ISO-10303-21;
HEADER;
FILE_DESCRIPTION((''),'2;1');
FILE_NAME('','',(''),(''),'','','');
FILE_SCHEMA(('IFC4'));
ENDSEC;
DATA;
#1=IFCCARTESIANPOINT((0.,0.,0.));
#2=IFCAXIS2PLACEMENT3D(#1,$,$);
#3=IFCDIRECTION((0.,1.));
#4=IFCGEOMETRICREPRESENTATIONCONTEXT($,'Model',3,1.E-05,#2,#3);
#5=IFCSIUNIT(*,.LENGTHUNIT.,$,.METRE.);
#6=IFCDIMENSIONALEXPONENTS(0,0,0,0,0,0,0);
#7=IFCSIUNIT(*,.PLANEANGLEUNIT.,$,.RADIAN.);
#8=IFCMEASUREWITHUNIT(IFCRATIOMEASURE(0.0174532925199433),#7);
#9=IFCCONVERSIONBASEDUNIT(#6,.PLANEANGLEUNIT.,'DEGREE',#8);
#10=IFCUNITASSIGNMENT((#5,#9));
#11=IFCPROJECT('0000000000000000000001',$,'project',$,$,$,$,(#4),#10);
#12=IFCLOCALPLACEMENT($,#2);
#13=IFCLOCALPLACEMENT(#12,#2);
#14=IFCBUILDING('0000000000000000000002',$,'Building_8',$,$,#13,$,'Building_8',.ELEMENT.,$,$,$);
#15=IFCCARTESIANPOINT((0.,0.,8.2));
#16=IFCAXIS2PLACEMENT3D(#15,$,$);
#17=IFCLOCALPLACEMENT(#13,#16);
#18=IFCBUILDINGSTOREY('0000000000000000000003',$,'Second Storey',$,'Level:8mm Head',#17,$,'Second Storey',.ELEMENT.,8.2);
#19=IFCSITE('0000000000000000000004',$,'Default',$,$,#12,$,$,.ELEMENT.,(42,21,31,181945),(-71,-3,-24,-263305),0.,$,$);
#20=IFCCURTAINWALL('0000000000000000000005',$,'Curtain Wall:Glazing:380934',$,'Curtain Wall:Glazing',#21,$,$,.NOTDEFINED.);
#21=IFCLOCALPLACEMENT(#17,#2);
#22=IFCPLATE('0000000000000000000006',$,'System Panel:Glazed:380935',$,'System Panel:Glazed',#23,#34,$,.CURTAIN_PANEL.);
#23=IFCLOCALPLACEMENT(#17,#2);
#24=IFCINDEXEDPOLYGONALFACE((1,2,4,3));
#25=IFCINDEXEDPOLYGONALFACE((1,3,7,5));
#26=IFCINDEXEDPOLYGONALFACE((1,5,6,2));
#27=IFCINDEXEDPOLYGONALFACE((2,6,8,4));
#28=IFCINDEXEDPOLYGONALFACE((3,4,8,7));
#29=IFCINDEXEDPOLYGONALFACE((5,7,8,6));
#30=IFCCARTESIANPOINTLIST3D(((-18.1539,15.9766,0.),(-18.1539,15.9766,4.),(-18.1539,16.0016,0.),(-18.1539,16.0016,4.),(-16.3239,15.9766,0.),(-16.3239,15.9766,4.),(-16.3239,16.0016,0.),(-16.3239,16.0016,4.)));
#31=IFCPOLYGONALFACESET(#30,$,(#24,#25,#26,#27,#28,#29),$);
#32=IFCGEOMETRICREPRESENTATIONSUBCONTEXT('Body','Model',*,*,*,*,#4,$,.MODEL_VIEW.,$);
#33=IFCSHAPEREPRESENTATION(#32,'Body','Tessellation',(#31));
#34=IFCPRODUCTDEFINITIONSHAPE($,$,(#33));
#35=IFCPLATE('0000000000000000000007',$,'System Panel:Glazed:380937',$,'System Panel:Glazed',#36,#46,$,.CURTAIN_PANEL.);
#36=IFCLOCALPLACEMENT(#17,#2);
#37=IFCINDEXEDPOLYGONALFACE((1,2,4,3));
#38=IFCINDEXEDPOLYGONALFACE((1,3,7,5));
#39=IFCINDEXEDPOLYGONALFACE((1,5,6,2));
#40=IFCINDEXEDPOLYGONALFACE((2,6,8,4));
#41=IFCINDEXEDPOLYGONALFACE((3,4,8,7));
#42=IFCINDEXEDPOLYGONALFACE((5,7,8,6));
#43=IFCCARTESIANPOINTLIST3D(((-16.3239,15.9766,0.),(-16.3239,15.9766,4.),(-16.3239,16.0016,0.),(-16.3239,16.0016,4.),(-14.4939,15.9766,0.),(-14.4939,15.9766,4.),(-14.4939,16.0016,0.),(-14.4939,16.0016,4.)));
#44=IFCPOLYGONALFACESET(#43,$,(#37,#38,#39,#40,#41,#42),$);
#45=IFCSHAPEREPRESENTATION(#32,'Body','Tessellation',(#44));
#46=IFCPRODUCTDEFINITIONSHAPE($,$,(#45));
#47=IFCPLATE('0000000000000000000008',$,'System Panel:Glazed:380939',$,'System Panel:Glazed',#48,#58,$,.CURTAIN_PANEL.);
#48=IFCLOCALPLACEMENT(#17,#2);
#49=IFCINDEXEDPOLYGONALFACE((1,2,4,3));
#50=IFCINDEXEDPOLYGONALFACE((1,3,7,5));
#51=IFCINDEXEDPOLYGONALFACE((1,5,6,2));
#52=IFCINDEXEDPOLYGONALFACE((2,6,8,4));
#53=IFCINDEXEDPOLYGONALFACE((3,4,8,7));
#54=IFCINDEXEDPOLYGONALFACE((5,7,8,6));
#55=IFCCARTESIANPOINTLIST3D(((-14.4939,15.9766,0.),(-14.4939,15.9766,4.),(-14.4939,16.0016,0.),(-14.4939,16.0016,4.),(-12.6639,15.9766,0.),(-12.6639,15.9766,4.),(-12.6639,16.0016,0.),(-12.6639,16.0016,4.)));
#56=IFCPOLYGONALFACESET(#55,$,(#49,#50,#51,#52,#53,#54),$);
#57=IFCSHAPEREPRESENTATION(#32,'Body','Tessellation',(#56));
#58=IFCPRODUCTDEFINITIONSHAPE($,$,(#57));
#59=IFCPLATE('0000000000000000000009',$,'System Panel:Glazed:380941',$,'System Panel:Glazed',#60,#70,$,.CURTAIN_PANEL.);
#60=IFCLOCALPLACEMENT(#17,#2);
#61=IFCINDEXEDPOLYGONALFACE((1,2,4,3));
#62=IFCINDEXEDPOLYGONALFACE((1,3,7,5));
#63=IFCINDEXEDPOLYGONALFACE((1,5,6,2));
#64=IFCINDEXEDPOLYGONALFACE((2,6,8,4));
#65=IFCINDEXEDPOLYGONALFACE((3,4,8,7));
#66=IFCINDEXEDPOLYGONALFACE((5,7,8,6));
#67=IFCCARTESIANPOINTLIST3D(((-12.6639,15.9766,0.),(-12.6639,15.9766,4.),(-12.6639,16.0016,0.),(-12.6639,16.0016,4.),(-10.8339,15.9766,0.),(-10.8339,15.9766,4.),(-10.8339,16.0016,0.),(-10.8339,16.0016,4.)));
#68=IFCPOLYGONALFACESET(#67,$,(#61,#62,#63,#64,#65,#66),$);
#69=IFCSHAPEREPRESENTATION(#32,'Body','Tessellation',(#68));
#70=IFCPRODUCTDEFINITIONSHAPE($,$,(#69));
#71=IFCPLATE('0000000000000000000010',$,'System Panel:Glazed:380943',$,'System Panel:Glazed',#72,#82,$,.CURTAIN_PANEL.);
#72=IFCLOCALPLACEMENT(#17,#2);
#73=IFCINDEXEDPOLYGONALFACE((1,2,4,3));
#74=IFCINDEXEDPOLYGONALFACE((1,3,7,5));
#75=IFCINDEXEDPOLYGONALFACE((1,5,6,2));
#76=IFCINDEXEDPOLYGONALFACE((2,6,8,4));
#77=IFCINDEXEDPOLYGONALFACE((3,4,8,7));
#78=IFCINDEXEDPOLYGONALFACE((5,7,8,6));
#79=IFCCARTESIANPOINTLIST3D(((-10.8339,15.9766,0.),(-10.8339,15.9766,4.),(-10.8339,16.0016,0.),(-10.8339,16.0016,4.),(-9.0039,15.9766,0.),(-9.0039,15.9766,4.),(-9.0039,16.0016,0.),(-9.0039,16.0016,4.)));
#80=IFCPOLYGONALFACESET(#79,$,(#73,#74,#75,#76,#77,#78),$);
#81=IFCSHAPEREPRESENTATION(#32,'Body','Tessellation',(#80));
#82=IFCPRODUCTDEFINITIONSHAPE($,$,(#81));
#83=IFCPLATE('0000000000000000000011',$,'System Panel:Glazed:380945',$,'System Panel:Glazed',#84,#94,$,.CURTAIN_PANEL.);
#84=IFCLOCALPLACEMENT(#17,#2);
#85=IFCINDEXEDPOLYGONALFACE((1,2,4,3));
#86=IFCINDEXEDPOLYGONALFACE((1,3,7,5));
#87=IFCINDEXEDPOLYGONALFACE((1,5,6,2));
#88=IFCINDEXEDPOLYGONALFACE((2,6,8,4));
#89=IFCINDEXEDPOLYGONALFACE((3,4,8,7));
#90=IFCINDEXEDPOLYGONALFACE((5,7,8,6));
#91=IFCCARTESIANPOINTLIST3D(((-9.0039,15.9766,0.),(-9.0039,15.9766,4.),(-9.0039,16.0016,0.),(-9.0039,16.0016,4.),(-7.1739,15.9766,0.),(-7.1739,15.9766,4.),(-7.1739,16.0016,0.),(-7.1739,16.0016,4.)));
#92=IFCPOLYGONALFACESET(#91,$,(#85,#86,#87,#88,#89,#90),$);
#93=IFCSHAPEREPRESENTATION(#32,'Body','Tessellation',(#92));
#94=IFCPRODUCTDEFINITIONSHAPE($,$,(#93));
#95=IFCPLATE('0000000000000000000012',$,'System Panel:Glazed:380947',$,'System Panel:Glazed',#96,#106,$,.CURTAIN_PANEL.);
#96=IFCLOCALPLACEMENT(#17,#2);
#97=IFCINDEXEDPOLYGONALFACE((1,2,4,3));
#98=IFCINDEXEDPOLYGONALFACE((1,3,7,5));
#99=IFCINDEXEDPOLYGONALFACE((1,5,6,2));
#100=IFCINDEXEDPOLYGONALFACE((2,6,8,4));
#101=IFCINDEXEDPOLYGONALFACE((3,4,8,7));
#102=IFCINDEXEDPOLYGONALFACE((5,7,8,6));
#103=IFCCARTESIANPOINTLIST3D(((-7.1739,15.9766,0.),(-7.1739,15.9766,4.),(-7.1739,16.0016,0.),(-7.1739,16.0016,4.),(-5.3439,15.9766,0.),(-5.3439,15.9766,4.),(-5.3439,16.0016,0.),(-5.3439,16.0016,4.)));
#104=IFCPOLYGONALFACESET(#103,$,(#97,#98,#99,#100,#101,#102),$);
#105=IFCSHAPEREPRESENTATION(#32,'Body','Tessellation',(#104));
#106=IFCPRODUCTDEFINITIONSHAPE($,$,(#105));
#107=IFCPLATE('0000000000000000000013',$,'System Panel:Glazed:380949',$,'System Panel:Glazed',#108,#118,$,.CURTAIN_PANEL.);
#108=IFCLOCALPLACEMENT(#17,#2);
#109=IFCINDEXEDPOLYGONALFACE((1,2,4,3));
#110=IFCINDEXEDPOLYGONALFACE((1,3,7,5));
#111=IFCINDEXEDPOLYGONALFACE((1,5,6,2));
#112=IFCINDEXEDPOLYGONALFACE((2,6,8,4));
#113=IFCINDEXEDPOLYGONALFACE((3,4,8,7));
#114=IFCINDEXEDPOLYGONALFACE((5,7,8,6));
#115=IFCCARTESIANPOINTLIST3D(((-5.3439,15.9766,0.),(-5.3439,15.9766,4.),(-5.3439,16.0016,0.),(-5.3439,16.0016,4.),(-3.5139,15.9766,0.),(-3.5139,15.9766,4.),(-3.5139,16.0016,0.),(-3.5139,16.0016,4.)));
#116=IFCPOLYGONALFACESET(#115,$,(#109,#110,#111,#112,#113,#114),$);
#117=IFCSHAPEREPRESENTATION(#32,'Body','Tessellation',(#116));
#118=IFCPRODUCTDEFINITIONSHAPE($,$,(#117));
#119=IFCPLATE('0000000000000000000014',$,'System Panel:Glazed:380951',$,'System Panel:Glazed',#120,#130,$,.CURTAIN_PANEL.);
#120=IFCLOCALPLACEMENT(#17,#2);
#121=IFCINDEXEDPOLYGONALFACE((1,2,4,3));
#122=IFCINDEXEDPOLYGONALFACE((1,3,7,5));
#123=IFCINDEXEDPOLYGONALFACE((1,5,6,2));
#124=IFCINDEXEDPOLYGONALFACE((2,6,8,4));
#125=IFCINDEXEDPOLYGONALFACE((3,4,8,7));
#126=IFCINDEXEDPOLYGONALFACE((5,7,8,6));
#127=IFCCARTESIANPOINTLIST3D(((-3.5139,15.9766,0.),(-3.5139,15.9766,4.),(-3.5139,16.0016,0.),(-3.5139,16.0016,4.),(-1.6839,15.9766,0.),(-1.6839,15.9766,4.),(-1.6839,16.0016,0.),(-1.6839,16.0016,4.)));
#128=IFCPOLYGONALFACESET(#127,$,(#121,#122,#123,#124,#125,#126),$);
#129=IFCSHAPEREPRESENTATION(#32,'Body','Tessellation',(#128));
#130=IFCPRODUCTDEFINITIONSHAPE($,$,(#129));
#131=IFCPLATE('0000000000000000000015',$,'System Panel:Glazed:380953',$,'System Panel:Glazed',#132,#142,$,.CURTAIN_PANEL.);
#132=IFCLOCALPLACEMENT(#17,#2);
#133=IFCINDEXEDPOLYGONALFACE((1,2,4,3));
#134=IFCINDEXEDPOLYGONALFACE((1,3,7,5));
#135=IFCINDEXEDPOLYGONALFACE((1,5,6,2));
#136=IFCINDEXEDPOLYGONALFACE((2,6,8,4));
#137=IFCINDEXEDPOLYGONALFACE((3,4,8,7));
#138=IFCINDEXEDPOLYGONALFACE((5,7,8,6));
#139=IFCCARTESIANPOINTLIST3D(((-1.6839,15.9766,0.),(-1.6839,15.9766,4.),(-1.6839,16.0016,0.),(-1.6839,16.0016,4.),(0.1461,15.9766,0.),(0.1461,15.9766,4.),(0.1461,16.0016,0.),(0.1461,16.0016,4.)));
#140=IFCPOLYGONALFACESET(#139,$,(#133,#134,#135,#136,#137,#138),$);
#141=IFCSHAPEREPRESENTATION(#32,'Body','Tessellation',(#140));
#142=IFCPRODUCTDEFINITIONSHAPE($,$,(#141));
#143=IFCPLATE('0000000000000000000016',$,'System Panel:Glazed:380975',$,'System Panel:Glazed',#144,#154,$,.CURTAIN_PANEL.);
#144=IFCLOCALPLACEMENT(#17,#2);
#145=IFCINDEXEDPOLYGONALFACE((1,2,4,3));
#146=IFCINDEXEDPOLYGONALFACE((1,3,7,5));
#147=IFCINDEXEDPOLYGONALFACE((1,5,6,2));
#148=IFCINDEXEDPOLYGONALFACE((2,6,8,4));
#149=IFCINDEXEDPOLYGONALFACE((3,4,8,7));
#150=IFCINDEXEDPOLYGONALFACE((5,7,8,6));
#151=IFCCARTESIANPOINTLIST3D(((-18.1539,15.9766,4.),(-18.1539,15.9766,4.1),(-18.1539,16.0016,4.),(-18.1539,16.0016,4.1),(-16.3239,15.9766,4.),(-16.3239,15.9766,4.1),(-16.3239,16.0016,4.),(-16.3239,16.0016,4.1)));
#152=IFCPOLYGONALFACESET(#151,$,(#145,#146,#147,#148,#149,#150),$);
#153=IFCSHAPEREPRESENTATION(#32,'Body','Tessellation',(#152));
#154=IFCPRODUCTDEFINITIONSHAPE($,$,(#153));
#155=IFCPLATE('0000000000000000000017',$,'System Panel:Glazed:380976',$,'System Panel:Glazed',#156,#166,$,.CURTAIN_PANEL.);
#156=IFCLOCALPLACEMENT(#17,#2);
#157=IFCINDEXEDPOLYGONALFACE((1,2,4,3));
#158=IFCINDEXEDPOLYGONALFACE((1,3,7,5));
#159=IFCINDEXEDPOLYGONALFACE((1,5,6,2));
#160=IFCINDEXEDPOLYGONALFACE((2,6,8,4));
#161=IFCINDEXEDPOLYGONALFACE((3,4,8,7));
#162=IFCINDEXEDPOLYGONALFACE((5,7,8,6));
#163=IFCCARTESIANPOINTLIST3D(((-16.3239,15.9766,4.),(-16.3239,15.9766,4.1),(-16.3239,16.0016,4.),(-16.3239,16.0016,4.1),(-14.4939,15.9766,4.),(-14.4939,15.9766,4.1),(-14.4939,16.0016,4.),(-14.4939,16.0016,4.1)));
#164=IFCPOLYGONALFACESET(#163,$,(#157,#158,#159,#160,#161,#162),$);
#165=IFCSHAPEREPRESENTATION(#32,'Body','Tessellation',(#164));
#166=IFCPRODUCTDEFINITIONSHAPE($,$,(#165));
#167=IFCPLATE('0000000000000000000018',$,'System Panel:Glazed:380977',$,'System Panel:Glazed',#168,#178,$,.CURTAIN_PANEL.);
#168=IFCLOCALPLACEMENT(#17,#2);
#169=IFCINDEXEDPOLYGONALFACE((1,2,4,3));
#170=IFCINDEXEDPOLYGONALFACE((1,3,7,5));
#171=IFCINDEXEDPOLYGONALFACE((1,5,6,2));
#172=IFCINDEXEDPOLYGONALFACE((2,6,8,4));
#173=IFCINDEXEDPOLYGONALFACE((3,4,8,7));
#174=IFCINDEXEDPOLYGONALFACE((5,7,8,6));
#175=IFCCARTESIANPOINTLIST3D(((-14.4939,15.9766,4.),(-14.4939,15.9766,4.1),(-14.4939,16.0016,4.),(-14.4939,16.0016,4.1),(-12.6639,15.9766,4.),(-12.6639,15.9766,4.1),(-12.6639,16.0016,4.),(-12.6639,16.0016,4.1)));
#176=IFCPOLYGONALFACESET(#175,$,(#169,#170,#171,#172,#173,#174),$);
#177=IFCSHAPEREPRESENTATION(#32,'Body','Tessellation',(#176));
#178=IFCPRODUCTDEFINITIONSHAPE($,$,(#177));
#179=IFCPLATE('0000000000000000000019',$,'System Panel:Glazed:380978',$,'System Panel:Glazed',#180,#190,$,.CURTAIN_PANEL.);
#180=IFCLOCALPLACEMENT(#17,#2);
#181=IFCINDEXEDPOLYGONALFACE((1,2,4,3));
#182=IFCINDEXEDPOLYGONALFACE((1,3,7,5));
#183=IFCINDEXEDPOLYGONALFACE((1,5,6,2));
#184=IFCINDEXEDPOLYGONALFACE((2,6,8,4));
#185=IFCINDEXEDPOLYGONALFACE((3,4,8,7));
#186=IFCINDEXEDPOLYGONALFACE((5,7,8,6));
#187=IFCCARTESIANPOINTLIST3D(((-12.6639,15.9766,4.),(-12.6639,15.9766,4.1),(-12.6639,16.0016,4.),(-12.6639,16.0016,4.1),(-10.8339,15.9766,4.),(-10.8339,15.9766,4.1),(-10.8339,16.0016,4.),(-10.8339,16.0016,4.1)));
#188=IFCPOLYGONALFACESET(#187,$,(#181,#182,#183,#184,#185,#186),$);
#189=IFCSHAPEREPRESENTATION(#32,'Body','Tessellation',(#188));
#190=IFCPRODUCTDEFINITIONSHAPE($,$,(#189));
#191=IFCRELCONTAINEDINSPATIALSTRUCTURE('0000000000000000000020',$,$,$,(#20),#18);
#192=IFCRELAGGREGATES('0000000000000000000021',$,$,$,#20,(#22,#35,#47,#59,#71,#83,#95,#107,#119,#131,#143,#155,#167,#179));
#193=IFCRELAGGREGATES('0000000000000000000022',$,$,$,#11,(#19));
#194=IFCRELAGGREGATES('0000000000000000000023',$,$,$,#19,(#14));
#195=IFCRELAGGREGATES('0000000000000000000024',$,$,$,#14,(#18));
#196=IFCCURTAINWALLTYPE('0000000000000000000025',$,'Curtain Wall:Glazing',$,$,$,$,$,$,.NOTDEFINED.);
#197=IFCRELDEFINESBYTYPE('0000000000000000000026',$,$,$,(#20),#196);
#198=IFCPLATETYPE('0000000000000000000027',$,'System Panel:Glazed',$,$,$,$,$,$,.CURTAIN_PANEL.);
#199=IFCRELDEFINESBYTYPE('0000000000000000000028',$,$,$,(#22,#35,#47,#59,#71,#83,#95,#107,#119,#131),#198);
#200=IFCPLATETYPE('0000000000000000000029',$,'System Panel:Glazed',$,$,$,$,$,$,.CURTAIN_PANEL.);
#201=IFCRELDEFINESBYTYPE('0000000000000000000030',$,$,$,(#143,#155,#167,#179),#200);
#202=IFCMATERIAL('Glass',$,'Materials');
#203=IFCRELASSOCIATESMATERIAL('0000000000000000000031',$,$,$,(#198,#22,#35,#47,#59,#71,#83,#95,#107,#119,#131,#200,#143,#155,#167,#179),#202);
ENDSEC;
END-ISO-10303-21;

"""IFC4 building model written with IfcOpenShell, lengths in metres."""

from ifc_helpers import new_model, entity, si_unit, converted_unit, direction, frame, origin, place, context, subcontext, project, spatial, indexed_curve, outline, extrude, source, transform, mapped, material, type_object, type_shapes, element, aggregate, save


model = new_model("IFC4")

# Units and contexts
model_context = context("Model", 3, precision=1e-05, world=origin(), true_north=direction((0.0, 1.0)))
body_context = subcontext(model_context, "Body", "Model", "MODEL_VIEW")
ifc_project = project(units=[si_unit("LENGTHUNIT", "METRE"), converted_unit("PLANEANGLEUNIT", "DEGREE", entity("IfcRatioMeasure", 0.0174532925199433), si_unit("PLANEANGLEUNIT", "RADIAN"), dimensions=[0, 0, 0, 0, 0, 0, 0])], contexts=[model_context])

# Site, building, storey
site_placement = place(None, origin())
site = spatial("IfcSite", under=ifc_project, at=site_placement, Name="Default", CompositionType="ELEMENT", RefLatitude=(42, 21, 31, 181945), RefLongitude=(-71, -3, -24, -263305), RefElevation=0.0)
building_placement = place(site_placement, origin())
building = spatial("IfcBuilding", under=site, at=building_placement, Name="Building_8", LongName="Building_8", CompositionType="ELEMENT")
storey_placement = place(building_placement, frame((0.0, 0.0, 8.2)))
storey = spatial("IfcBuildingStorey", under=building, at=storey_placement, Name="Second Storey", ObjectType="Level:8mm Head", LongName="Second Storey", CompositionType="ELEMENT", Elevation=8.2)

# Curtain wall, plates
curtain_wall_type = type_object("IfcCurtainWallType", Name="Curtain Wall:Glazing", PredefinedType="NOTDEFINED")
curtain_wall_placement = place(storey_placement, frame((0.0, 0.0, -8.2)))
curtain_wall = element("IfcCurtainWall", 1, at=curtain_wall_placement, inside=storey, type_object=curtain_wall_type, Name="Curtain Wall:Glazing:380934", ObjectType="Curtain Wall:Glazing", PredefinedType="NOTDEFINED")
ifc_material_1 = material(Name="Glass", Category="Materials")
plate_type_1 = type_object("IfcPlateType", Name="System Panel:Glazed", PredefinedType="CURTAIN_PANEL", material=ifc_material_1)
shared_shape_1 = source(origin(), body_context, "Body", "SweptSolid", [
    extrude(outline(indexed_curve([(-0.0125, -0.915), (0.0125, -0.915), (0.0125, 0.915), (-0.0125, 0.915), (-0.0125, -0.915)], self_intersect=False)), frame((0.0, 0.037, 0.0), z_axis=(0.0, 0.0, 1.0), x_axis=(0.0, 1.0, 0.0)), (0.0, 0.0, 1.0), 4.0),
])
type_shapes(plate_type_1, [shared_shape_1])
plate_1_placement = place(curtain_wall_placement, frame((-17.2389, 15.9521, 8.2)))
plate_1 = element("IfcPlate", 2, at=plate_1_placement, type_object=plate_type_1, material=ifc_material_1, Name="System Panel:Glazed:380935", ObjectType="System Panel:Glazed", PredefinedType="CURTAIN_PANEL", context=body_context, shape_type="MappedRepresentation", body=[
    mapped(shared_shape_1, transform((0.0, 0.0, 0.0), scale=1.0)),
])
plate_2_placement = place(curtain_wall_placement, frame((-15.4089, 15.9521, 8.2)))
plate_2 = element("IfcPlate", 3, at=plate_2_placement, type_object=plate_type_1, material=ifc_material_1, Name="System Panel:Glazed:380937", ObjectType="System Panel:Glazed", PredefinedType="CURTAIN_PANEL", context=body_context, shape_type="MappedRepresentation", body=[
    mapped(shared_shape_1, transform((0.0, 0.0, 0.0), scale=1.0)),
])
plate_3_placement = place(curtain_wall_placement, frame((-13.5789, 15.9521, 8.2)))
plate_3 = element("IfcPlate", 4, at=plate_3_placement, type_object=plate_type_1, material=ifc_material_1, Name="System Panel:Glazed:380939", ObjectType="System Panel:Glazed", PredefinedType="CURTAIN_PANEL", context=body_context, shape_type="MappedRepresentation", body=[
    mapped(shared_shape_1, transform((0.0, 0.0, 0.0), scale=1.0)),
])
plate_4_placement = place(curtain_wall_placement, frame((-11.7489, 15.9521, 8.2)))
plate_4 = element("IfcPlate", 5, at=plate_4_placement, type_object=plate_type_1, material=ifc_material_1, Name="System Panel:Glazed:380941", ObjectType="System Panel:Glazed", PredefinedType="CURTAIN_PANEL", context=body_context, shape_type="MappedRepresentation", body=[
    mapped(shared_shape_1, transform((0.0, 0.0, 0.0), scale=1.0)),
])
plate_5_placement = place(curtain_wall_placement, frame((-9.9189, 15.9521, 8.2)))
plate_5 = element("IfcPlate", 6, at=plate_5_placement, type_object=plate_type_1, material=ifc_material_1, Name="System Panel:Glazed:380943", ObjectType="System Panel:Glazed", PredefinedType="CURTAIN_PANEL", context=body_context, shape_type="MappedRepresentation", body=[
    mapped(shared_shape_1, transform((0.0, 0.0, 0.0), scale=1.0)),
])
plate_6_placement = place(curtain_wall_placement, frame((-8.0889, 15.9521, 8.2)))
plate_6 = element("IfcPlate", 7, at=plate_6_placement, type_object=plate_type_1, material=ifc_material_1, Name="System Panel:Glazed:380945", ObjectType="System Panel:Glazed", PredefinedType="CURTAIN_PANEL", context=body_context, shape_type="MappedRepresentation", body=[
    mapped(shared_shape_1, transform((0.0, 0.0, 0.0), scale=1.0)),
])
plate_7_placement = place(curtain_wall_placement, frame((-6.2589, 15.9521, 8.2)))
plate_7 = element("IfcPlate", 8, at=plate_7_placement, type_object=plate_type_1, material=ifc_material_1, Name="System Panel:Glazed:380947", ObjectType="System Panel:Glazed", PredefinedType="CURTAIN_PANEL", context=body_context, shape_type="MappedRepresentation", body=[
    mapped(shared_shape_1, transform((0.0, 0.0, 0.0), scale=1.0)),
])
plate_8_placement = place(curtain_wall_placement, frame((-4.4289, 15.9521, 8.2)))
plate_8 = element("IfcPlate", 9, at=plate_8_placement, type_object=plate_type_1, material=ifc_material_1, Name="System Panel:Glazed:380949", ObjectType="System Panel:Glazed", PredefinedType="CURTAIN_PANEL", context=body_context, shape_type="MappedRepresentation", body=[
    mapped(shared_shape_1, transform((0.0, 0.0, 0.0), scale=1.0)),
])
plate_9_placement = place(curtain_wall_placement, frame((-2.5989, 15.9521, 8.2)))
plate_9 = element("IfcPlate", 10, at=plate_9_placement, type_object=plate_type_1, material=ifc_material_1, Name="System Panel:Glazed:380951", ObjectType="System Panel:Glazed", PredefinedType="CURTAIN_PANEL", context=body_context, shape_type="MappedRepresentation", body=[
    mapped(shared_shape_1, transform((0.0, 0.0, 0.0), scale=1.0)),
])
plate_10_placement = place(curtain_wall_placement, frame((-0.7689, 15.9521, 8.2)))
plate_10 = element("IfcPlate", 11, at=plate_10_placement, type_object=plate_type_1, material=ifc_material_1, Name="System Panel:Glazed:380953", ObjectType="System Panel:Glazed", PredefinedType="CURTAIN_PANEL", context=body_context, shape_type="MappedRepresentation", body=[
    mapped(shared_shape_1, transform((0.0, 0.0, 0.0), scale=1.0)),
])
plate_type_2 = type_object("IfcPlateType", Name="System Panel:Glazed", PredefinedType="CURTAIN_PANEL", material=ifc_material_1)
shared_shape_2 = source(origin(), body_context, "Body", "SweptSolid", [
    extrude(outline(indexed_curve([(-0.0125, -0.915), (0.0125, -0.915), (0.0125, 0.915), (-0.0125, 0.915), (-0.0125, -0.915)], self_intersect=False)), frame((0.0, 0.037, 0.0), z_axis=(0.0, 0.0, 1.0), x_axis=(0.0, 1.0, 0.0)), (0.0, 0.0, 1.0), 0.1),
])
type_shapes(plate_type_2, [shared_shape_2])
plate_11_placement = place(curtain_wall_placement, frame((-17.2389, 15.9521, 12.2)))
plate_11 = element("IfcPlate", 12, at=plate_11_placement, type_object=plate_type_2, material=ifc_material_1, Name="System Panel:Glazed:380975", ObjectType="System Panel:Glazed", PredefinedType="CURTAIN_PANEL", context=body_context, shape_type="MappedRepresentation", body=[
    mapped(shared_shape_2, transform((0.0, 0.0, 0.0), scale=1.0)),
])
plate_12_placement = place(curtain_wall_placement, frame((-15.4089, 15.9521, 12.2)))
plate_12 = element("IfcPlate", 13, at=plate_12_placement, type_object=plate_type_2, material=ifc_material_1, Name="System Panel:Glazed:380976", ObjectType="System Panel:Glazed", PredefinedType="CURTAIN_PANEL", context=body_context, shape_type="MappedRepresentation", body=[
    mapped(shared_shape_2, transform((0.0, 0.0, 0.0), scale=1.0)),
])
plate_13_placement = place(curtain_wall_placement, frame((-13.5789, 15.9521, 12.2)))
plate_13 = element("IfcPlate", 14, at=plate_13_placement, type_object=plate_type_2, material=ifc_material_1, Name="System Panel:Glazed:380977", ObjectType="System Panel:Glazed", PredefinedType="CURTAIN_PANEL", context=body_context, shape_type="MappedRepresentation", body=[
    mapped(shared_shape_2, transform((0.0, 0.0, 0.0), scale=1.0)),
])
plate_14_placement = place(curtain_wall_placement, frame((-11.7489, 15.9521, 12.2)))
plate_14 = element("IfcPlate", 15, at=plate_14_placement, type_object=plate_type_2, material=ifc_material_1, Name="System Panel:Glazed:380978", ObjectType="System Panel:Glazed", PredefinedType="CURTAIN_PANEL", context=body_context, shape_type="MappedRepresentation", body=[
    mapped(shared_shape_2, transform((0.0, 0.0, 0.0), scale=1.0)),
])
aggregate(curtain_wall, [plate_1, plate_2, plate_3, plate_4, plate_5, plate_6, plate_7, plate_8, plate_9, plate_10, plate_11, plate_12, plate_13, plate_14])

save(model, "model.ifc")
